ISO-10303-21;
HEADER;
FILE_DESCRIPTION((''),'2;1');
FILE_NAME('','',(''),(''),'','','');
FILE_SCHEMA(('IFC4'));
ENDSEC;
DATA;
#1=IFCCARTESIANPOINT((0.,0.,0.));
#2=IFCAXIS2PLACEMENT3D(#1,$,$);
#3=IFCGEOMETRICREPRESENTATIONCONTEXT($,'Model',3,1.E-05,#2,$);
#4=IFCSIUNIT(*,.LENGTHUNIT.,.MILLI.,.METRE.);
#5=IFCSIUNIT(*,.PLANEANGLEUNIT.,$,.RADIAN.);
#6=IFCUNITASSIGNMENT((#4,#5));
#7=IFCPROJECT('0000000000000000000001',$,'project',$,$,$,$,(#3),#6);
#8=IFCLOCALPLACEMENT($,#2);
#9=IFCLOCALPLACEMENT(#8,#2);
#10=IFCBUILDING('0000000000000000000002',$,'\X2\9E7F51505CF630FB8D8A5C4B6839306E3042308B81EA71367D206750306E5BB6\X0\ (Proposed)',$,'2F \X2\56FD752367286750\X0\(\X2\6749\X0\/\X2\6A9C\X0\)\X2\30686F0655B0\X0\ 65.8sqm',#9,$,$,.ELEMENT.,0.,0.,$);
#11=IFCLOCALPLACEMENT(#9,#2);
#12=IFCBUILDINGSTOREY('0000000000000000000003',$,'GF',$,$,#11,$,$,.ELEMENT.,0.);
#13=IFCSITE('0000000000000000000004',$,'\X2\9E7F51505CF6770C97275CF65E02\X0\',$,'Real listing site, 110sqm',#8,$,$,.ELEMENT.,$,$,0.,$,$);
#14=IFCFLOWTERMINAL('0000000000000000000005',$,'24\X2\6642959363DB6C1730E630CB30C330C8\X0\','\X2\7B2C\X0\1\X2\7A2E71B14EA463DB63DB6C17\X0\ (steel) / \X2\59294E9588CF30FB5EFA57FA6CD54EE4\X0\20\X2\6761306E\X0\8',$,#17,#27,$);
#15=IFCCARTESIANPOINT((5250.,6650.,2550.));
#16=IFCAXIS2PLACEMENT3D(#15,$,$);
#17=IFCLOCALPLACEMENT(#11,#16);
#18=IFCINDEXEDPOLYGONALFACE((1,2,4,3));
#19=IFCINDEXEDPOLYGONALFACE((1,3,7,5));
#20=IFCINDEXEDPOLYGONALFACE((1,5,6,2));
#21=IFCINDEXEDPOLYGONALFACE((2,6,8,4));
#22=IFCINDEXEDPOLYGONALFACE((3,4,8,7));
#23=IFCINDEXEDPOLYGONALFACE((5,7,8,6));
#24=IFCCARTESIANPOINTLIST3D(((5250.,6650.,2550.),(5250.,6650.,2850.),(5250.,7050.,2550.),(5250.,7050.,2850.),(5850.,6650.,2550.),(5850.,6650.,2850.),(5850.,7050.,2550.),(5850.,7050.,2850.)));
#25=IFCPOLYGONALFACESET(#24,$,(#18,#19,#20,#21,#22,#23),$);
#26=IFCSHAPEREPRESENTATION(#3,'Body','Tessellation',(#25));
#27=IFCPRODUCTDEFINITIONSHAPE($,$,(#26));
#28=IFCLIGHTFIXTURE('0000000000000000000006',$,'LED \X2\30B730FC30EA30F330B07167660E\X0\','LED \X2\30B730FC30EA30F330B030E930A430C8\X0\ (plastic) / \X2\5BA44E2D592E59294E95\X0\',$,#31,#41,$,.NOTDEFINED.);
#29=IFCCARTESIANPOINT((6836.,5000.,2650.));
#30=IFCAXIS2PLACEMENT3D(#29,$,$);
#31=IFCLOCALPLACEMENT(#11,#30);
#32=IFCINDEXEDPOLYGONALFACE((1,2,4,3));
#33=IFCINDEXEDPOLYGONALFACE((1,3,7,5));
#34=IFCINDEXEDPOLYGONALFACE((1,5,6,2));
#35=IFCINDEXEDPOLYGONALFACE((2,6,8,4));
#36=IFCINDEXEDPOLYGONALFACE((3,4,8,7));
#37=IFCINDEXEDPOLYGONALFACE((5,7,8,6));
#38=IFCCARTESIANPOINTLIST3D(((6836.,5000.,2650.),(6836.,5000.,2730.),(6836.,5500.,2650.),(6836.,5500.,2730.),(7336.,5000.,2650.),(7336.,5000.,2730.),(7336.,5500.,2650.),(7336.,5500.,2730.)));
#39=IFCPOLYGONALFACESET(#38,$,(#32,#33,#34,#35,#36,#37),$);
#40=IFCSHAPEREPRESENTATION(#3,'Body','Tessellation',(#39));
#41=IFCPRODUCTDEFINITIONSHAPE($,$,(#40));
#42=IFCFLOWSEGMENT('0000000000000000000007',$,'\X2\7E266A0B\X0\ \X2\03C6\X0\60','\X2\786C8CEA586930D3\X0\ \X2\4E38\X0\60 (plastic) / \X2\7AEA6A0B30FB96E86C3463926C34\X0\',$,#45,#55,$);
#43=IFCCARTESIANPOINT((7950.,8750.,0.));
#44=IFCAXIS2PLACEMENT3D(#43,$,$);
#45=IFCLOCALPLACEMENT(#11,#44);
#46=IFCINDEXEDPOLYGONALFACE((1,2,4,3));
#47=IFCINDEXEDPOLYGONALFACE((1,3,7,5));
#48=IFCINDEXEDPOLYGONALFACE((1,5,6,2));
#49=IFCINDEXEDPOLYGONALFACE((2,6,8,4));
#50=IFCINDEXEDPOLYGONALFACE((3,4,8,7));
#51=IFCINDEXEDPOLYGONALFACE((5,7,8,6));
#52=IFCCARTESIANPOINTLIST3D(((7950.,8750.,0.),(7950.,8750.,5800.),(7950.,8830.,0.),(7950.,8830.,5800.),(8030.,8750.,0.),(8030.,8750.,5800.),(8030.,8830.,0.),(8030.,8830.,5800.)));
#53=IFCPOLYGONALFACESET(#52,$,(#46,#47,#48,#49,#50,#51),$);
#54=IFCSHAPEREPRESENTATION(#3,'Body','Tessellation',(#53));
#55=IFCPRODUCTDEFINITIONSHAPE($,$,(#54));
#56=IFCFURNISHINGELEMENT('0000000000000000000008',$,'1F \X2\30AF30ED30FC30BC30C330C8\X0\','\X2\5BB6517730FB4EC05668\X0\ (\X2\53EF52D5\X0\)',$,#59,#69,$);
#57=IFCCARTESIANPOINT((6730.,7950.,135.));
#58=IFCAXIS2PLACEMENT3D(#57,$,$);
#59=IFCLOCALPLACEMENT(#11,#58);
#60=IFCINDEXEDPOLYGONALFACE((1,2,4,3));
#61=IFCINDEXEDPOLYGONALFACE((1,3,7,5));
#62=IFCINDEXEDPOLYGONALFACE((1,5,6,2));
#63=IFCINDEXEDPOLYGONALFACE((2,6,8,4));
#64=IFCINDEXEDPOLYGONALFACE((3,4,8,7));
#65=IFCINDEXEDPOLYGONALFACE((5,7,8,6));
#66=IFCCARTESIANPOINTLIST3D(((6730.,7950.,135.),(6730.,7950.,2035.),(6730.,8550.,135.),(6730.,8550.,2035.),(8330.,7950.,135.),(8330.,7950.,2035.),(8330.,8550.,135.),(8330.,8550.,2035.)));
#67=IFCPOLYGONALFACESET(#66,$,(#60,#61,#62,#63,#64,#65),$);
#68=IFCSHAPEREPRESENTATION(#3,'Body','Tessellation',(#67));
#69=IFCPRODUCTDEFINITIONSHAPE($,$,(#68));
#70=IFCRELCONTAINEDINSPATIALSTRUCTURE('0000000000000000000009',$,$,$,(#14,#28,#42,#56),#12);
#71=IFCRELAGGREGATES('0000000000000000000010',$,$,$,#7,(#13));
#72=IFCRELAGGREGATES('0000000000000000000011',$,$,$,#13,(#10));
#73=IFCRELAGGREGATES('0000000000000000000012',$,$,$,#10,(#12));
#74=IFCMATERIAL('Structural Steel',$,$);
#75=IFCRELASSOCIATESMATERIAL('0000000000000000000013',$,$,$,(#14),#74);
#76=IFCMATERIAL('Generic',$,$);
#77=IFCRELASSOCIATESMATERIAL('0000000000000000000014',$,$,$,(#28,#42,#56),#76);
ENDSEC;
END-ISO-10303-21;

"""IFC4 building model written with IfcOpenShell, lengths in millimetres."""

from ifc_helpers import new_model, si_unit, frame, frame_2d, origin, place, context, project, spatial, rectangle, extrude, material, element, save


model = new_model("IFC4")

# Units and contexts
model_context = context("Model", 3, precision=1e-05, world=origin())
ifc_project = project(units=[si_unit("LENGTHUNIT", "METRE", prefix="MILLI"), si_unit("PLANEANGLEUNIT", "RADIAN")], contexts=[model_context])

# Site, building, storey
site_placement = place(None, origin())
site = spatial("IfcSite", under=ifc_project, at=site_placement, Name="鹿児島県霧島市", ObjectType="Real listing site, 110sqm", CompositionType="ELEMENT", RefElevation=0.0)
building_placement = place(site_placement, origin())
building = spatial("IfcBuilding", under=site, at=building_placement, Name="鹿児島・越屋根のある自然素材の家 (Proposed)", ObjectType="2F 国産木材(杉/檜)と漆喰 65.8sqm", CompositionType="ELEMENT", ElevationOfRefHeight=0.0, ElevationOfTerrain=0.0)
storey_placement = place(building_placement, origin())
storey = spatial("IfcBuildingStorey", under=building, at=storey_placement, Name="GF", CompositionType="ELEMENT", Elevation=0.0)

# Shared definitions
ifc_material_1 = material(Name="Generic")

# Flow terminal
ifc_material_2 = material(Name="Structural Steel")
flow_terminal_placement = place(storey_placement, frame((5250.0, 6650.0, 2550.0)))
element("IfcFlowTerminal", 1, at=flow_terminal_placement, inside=storey, material=ifc_material_2, Name="24時間換気ユニット", Description="第1種熱交換換気 (steel) / 天井裏・建基法令20条の8", context=model_context, shape_type="SweptSolid", body=[
    extrude(rectangle(XDim=600.0, YDim=400.0, at=frame_2d((300.0, 200.0))), frame((5250.0, 6650.0, 2550.0)), (0.0, 0.0, 1.0), 300.0),
])

# Light fixture
light_fixture_placement = place(storey_placement, frame((6836.0, 5000.0, 2650.0)))
element("IfcLightFixture", 2, at=light_fixture_placement, inside=storey, material=ifc_material_1, Name="LED シーリング照明", Description="LED シーリングライト (plastic) / 室中央天井", PredefinedType="NOTDEFINED", context=model_context, shape_type="SweptSolid", body=[
    extrude(rectangle(XDim=500.0, YDim=500.0, at=frame_2d((250.0, 250.0))), frame((6836.0, 5000.0, 2650.0)), (0.0, 0.0, 1.0), 80.0),
])

# Flow segment
flow_segment_placement = place(storey_placement, frame((7950.0, 8750.0, 0.0)))
element("IfcFlowSegment", 3, at=flow_segment_placement, inside=storey, material=ifc_material_1, Name="縦樋 φ60", Description="硬質塩ビ 丸60 (plastic) / 竪樋・雨水排水", context=model_context, shape_type="SweptSolid", body=[
    extrude(rectangle(XDim=80.0, YDim=80.0, at=frame_2d((40.0, 40.0))), frame((7950.0, 8750.0, 0.0)), (0.0, 0.0, 1.0), 5800.0),
])

# Furnishing element
furnishing_placement = place(storey_placement, frame((6730.0, 7950.0, 135.0)))
element("IfcFurnishingElement", 4, at=furnishing_placement, inside=storey, material=ifc_material_1, Name="1F クローゼット", Description="家具・什器 (可動)", context=model_context, shape_type="SweptSolid", body=[
    extrude(rectangle(XDim=1600.0, YDim=600.0, at=frame_2d((800.0, 300.0))), frame((6730.0, 7950.0, 135.0)), (0.0, 0.0, 1.0), 1900.0),
])

save(model, "model.ifc")
